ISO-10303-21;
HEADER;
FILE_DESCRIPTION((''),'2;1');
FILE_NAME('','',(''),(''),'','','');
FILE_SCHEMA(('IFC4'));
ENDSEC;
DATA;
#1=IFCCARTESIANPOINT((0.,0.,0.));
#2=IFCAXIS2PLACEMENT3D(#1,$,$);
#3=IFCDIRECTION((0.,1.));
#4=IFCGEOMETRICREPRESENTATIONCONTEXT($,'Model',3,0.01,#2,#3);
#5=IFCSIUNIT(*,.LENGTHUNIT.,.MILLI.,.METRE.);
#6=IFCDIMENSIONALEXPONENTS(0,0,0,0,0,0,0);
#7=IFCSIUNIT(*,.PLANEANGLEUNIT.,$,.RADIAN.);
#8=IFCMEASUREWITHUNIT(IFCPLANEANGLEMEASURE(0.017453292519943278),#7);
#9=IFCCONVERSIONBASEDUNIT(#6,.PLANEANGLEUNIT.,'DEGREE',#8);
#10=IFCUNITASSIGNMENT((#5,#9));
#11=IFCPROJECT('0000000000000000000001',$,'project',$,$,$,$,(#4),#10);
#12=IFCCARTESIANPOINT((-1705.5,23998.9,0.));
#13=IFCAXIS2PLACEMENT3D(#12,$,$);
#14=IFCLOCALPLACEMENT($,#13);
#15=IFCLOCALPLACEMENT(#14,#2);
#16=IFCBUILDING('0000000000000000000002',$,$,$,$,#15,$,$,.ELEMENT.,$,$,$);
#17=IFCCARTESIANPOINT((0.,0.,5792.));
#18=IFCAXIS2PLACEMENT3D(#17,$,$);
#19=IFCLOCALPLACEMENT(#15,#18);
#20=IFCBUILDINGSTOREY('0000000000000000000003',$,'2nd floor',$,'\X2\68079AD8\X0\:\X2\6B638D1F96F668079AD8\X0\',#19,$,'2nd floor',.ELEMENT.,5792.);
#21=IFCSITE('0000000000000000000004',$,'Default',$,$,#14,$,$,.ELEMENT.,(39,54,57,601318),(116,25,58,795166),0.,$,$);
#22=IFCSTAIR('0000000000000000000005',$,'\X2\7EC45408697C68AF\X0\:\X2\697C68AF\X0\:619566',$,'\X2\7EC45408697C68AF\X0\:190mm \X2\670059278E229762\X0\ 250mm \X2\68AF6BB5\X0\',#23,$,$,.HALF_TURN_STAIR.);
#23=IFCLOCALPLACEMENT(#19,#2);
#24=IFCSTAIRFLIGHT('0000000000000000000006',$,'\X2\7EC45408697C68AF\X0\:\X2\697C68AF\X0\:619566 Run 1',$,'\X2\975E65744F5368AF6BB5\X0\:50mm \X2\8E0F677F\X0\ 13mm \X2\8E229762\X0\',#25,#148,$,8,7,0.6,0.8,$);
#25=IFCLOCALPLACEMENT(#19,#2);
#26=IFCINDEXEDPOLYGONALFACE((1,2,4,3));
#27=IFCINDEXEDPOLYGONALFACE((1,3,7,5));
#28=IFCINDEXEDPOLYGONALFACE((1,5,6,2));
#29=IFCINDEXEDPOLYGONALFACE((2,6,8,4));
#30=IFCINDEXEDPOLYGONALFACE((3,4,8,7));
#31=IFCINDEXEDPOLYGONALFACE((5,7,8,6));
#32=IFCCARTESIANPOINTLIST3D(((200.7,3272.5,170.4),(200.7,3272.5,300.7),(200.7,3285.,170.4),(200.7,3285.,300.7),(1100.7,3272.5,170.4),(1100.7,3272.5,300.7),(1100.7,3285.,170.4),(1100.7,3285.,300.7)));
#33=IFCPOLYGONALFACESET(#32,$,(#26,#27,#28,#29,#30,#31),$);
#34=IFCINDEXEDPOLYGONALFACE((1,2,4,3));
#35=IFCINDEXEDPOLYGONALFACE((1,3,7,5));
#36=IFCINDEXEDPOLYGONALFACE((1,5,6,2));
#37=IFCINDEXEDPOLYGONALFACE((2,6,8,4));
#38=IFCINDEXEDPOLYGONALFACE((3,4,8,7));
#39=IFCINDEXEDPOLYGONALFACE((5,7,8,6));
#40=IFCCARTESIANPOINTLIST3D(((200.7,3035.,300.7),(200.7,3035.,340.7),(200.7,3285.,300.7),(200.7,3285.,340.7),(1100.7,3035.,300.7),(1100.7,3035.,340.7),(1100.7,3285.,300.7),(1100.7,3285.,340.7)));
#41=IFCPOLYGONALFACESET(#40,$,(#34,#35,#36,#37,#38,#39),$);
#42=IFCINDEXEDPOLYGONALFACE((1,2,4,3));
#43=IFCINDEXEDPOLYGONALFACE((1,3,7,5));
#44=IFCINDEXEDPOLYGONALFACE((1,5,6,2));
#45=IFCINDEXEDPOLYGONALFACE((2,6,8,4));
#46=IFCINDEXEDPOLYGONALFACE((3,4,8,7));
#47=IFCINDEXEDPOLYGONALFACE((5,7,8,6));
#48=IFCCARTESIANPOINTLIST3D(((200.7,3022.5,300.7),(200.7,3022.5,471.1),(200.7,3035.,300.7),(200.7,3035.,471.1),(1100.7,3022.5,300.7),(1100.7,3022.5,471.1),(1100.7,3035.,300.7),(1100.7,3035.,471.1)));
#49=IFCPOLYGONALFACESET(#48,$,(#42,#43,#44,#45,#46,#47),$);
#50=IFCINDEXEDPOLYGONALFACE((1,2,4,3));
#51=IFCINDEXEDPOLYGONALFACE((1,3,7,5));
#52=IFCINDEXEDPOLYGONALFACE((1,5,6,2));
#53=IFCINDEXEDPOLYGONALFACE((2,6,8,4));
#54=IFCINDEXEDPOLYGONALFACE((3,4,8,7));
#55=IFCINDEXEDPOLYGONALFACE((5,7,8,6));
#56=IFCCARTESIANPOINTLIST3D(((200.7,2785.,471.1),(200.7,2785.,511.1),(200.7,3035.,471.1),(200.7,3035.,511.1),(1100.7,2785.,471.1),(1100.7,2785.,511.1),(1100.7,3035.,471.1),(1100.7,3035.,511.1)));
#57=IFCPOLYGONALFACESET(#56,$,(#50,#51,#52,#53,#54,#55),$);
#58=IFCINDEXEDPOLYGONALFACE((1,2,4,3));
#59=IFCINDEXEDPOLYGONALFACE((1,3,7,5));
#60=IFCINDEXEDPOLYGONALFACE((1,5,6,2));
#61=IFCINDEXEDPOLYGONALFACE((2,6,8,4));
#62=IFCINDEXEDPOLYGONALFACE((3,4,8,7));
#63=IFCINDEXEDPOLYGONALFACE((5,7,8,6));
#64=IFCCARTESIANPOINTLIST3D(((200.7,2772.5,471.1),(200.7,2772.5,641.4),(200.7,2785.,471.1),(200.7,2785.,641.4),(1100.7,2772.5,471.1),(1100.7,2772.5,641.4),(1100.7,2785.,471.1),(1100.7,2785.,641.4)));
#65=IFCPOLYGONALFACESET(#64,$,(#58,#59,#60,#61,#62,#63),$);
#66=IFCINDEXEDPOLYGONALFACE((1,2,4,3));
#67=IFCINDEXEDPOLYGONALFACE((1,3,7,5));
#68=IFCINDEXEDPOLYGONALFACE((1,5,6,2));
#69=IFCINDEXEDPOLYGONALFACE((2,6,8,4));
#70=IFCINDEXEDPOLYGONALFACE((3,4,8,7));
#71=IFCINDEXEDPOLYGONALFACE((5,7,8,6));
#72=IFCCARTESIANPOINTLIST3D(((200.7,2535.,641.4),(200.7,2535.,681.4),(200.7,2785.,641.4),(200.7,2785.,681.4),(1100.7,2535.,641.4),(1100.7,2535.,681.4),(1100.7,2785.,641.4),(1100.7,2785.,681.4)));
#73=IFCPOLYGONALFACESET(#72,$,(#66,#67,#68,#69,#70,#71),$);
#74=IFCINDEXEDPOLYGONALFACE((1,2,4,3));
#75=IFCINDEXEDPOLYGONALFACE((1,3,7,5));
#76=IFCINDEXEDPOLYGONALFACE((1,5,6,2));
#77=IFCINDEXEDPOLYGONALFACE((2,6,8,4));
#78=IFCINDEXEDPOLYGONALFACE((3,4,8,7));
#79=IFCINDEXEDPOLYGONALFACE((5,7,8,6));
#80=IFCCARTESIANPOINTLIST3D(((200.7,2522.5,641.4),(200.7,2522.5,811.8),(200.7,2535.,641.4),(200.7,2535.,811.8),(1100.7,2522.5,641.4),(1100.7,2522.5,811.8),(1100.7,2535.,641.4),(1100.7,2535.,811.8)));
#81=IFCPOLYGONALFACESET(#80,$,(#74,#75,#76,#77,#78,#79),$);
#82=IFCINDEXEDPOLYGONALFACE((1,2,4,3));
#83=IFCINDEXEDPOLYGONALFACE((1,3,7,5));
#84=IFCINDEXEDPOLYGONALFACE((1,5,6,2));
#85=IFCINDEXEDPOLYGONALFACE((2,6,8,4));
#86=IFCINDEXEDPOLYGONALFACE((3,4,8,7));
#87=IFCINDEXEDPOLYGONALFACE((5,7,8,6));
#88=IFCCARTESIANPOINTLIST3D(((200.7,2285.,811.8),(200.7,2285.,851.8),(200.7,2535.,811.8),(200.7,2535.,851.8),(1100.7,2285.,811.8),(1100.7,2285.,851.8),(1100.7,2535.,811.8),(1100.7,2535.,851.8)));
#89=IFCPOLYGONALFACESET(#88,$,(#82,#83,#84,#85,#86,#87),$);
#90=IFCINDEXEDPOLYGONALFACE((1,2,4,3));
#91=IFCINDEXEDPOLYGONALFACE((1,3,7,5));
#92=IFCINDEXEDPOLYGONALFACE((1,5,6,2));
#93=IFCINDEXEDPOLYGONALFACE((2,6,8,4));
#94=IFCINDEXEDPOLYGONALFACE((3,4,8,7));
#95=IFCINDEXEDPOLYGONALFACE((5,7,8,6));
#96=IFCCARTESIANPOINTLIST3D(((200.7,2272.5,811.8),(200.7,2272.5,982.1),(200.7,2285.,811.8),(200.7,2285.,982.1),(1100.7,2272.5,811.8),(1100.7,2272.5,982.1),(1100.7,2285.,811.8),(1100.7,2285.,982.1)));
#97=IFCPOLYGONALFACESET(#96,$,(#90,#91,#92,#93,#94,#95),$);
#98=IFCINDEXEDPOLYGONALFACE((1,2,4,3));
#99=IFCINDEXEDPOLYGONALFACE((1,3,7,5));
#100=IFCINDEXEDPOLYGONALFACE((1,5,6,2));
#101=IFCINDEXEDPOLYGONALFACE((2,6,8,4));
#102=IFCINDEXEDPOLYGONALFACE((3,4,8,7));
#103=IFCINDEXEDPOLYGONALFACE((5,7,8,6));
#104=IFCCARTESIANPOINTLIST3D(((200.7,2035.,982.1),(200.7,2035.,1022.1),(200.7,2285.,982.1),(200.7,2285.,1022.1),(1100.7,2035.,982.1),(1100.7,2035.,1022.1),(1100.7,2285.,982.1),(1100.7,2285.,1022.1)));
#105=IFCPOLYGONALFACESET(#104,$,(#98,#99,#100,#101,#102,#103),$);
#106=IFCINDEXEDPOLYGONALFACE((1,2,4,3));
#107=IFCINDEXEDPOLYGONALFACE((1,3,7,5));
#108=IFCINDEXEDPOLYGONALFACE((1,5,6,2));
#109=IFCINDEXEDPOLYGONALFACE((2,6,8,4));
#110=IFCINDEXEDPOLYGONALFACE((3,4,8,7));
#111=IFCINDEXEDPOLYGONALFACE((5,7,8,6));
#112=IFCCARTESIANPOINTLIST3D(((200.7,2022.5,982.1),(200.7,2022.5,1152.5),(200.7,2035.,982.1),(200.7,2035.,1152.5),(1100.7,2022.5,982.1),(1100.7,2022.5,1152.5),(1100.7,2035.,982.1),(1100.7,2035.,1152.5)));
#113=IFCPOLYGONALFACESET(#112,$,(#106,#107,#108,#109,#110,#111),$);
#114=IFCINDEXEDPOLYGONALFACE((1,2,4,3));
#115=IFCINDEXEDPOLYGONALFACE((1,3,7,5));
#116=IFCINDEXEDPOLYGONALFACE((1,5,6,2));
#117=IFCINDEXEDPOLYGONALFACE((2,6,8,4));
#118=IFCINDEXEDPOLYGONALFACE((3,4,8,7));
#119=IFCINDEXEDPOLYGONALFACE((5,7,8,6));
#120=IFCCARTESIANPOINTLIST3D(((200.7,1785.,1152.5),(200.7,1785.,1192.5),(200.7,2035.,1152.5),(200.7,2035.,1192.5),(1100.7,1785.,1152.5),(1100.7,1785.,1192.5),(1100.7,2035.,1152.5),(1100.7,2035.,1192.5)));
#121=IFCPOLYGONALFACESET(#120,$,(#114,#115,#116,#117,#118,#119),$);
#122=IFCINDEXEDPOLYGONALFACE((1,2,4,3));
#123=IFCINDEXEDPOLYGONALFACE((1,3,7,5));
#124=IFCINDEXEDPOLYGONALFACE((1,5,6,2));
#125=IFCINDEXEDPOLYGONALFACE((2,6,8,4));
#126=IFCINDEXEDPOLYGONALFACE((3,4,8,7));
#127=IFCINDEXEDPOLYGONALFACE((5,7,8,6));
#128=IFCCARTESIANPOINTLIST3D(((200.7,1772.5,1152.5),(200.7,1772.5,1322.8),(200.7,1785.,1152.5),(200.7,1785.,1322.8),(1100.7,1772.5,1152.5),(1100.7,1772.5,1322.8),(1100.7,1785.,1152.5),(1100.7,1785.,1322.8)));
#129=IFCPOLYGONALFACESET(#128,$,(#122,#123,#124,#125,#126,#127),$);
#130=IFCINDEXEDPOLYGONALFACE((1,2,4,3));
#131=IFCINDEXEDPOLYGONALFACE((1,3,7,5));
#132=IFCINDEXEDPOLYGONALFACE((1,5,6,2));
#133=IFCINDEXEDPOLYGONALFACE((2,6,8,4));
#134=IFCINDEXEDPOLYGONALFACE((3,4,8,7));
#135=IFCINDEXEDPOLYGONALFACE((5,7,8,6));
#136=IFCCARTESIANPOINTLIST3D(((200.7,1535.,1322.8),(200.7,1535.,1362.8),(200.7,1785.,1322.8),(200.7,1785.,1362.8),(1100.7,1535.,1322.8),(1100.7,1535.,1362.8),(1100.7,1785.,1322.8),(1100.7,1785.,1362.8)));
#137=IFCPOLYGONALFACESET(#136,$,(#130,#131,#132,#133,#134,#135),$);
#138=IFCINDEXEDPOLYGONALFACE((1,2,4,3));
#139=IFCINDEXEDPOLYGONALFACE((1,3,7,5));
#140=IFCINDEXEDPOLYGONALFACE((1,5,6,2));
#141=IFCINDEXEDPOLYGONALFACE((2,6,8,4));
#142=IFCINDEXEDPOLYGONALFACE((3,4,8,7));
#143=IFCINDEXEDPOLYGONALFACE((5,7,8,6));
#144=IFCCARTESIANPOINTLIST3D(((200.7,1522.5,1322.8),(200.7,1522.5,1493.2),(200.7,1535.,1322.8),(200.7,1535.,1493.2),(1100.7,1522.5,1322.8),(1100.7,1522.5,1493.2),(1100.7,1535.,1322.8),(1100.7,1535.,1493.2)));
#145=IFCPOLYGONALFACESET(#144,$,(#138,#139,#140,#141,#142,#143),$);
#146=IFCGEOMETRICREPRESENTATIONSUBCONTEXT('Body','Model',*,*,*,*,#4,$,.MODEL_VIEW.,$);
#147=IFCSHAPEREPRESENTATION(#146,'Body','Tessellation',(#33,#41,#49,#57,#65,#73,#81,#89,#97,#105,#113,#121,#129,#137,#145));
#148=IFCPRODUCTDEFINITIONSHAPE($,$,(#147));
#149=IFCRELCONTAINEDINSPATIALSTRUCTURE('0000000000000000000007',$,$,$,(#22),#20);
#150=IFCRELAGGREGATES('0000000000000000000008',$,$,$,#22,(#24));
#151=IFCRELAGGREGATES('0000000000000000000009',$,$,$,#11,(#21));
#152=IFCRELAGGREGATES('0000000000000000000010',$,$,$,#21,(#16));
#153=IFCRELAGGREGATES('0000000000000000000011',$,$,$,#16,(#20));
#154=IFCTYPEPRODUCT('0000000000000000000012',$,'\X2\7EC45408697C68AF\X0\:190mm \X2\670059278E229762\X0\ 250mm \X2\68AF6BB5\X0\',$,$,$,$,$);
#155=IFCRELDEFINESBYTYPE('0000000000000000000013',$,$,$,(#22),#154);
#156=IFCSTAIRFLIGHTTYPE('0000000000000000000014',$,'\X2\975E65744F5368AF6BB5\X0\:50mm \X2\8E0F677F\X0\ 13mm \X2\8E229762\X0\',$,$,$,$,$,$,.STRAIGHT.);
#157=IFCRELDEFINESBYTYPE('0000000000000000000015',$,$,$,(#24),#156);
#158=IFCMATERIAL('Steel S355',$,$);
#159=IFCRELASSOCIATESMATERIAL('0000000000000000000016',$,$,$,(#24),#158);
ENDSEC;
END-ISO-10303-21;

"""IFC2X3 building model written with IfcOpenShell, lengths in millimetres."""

from ifc_helpers import new_model, entity, si_unit, converted_unit, direction, frame, frame_2d, origin, origin_2d_with_axis, place, context, subcontext, project, spatial, rectangle, extrude, material, type_object, element, aggregate, save


model = new_model("IFC2X3")

# Units and contexts
model_context = context("Model", 3, precision=0.01, world=origin(), true_north=direction((0.0, 1.0)))
body_context = subcontext(model_context, "Body", "Model", "MODEL_VIEW")
ifc_project = project(units=[si_unit("LENGTHUNIT", "METRE", prefix="MILLI"), converted_unit("PLANEANGLEUNIT", "DEGREE", entity("IfcPlaneAngleMeasure", 0.017453292519943278), si_unit("PLANEANGLEUNIT", "RADIAN"), dimensions=[0, 0, 0, 0, 0, 0, 0])], contexts=[model_context])

# Site, building, storey
site_placement = place(None, frame((-1705.5, 23998.9, 0.0)))
site = spatial("IfcSite", under=ifc_project, at=site_placement, Name="Default", CompositionType="ELEMENT", RefLatitude=(39, 54, 57, 601318), RefLongitude=(116, 25, 58, 795166), RefElevation=0.0)
building_placement = place(site_placement, origin())
building = spatial("IfcBuilding", under=site, at=building_placement, CompositionType="ELEMENT")
storey_placement = place(building_placement, frame((0.0, 0.0, 5792.0)))
storey = spatial("IfcBuildingStorey", under=building, at=storey_placement, Name="2nd floor", ObjectType="标高:正负零标高", LongName="2nd floor", CompositionType="ELEMENT", Elevation=5792.0)

# Stair
type_product = type_object("IfcTypeProduct", Name="组合楼梯:190mm 最大踢面 250mm 梯段")
stair_placement = place(storey_placement, origin())
stair = element("IfcStair", 1, at=stair_placement, inside=storey, type_object=type_product, Name="组合楼梯:楼梯:619566", ObjectType="组合楼梯:190mm 最大踢面 250mm 梯段", ShapeType="HALF_TURN_STAIR")
ifc_material_1 = material(Name="Steel S355")

# Stair flight
stair_flight_type = type_object("IfcStairFlightType", Name="非整体梯段:50mm 踏板 13mm 踢面", PredefinedType="STRAIGHT")
stair_flight_1_placement = place(stair_placement, origin())
stair_flight_1 = element("IfcStairFlight", 2, at=stair_flight_1_placement, type_object=stair_flight_type, material=ifc_material_1, Name="组合楼梯:楼梯:619566 Run 1", ObjectType="非整体梯段:50mm 踏板 13mm 踢面", NumberOfRiser=8, NumberOfTreads=7, RiserHeight=0.6, TreadLength=0.8, context=body_context, shape_type="SweptSolid", body=[
    extrude(rectangle(XDim=900.0, YDim=12.5, at=frame_2d((0.0, 0.0), x_axis=(1.0, 0.0))), frame((650.7, 3278.7, 170.4)), (0.0, 0.0, 1.0), 130.4),
    extrude(rectangle(XDim=250.0, YDim=900.0, at=frame_2d((0.0, 0.0), x_axis=(1.0, 0.0))), frame((650.7, 3160.0, 300.7), z_axis=(0.0, 0.0, 1.0), x_axis=(0.0, 1.0, 0.0)), (0.0, 0.0, 1.0), 40.0),
    extrude(rectangle(XDim=900.0, YDim=12.5, at=frame_2d((0.0, 0.0), x_axis=(1.0, 0.0))), frame((650.7, 3028.7, 300.7)), (0.0, 0.0, 1.0), 170.4),
    extrude(rectangle(XDim=250.0, YDim=900.0, at=frame_2d((0.0, 0.0), x_axis=(1.0, 0.0))), frame((650.7, 2910.0, 471.1), z_axis=(0.0, 0.0, 1.0), x_axis=(0.0, 1.0, 0.0)), (0.0, 0.0, 1.0), 40.0),
    extrude(rectangle(XDim=900.0, YDim=12.5, at=frame_2d((0.0, 0.0), x_axis=(1.0, 0.0))), frame((650.7, 2778.7, 471.1)), (0.0, 0.0, 1.0), 170.4),
    extrude(rectangle(XDim=250.0, YDim=900.0, at=frame_2d((0.0, 0.0), x_axis=(1.0, 0.0))), frame((650.7, 2660.0, 641.4), z_axis=(0.0, 0.0, 1.0), x_axis=(0.0, 1.0, 0.0)), (0.0, 0.0, 1.0), 40.0),
    extrude(rectangle(XDim=900.0, YDim=12.5, at=frame_2d((0.0, 0.0), x_axis=(1.0, 0.0))), frame((650.7, 2528.7, 641.4)), (0.0, 0.0, 1.0), 170.4),
    extrude(rectangle(XDim=250.0, YDim=900.0, at=origin_2d_with_axis()), frame((650.7, 2410.0, 811.8), z_axis=(0.0, 0.0, 1.0), x_axis=(0.0, 1.0, 0.0)), (0.0, 0.0, 1.0), 40.0),
    extrude(rectangle(XDim=900.0, YDim=12.5, at=origin_2d_with_axis()), frame((650.7, 2278.7, 811.8)), (0.0, 0.0, 1.0), 170.4),
    extrude(rectangle(XDim=250.0, YDim=900.0, at=origin_2d_with_axis()), frame((650.7, 2160.0, 982.1), z_axis=(0.0, 0.0, 1.0), x_axis=(0.0, 1.0, 0.0)), (0.0, 0.0, 1.0), 40.0),
    extrude(rectangle(XDim=900.0, YDim=12.5, at=origin_2d_with_axis()), frame((650.7, 2028.7, 982.1)), (0.0, 0.0, 1.0), 170.4),
    extrude(rectangle(XDim=250.0, YDim=900.0, at=frame_2d((0.0, 0.0), x_axis=(1.0, 0.0))), frame((650.7, 1910.0, 1152.5), z_axis=(0.0, 0.0, 1.0), x_axis=(0.0, 1.0, 0.0)), (0.0, 0.0, 1.0), 40.0),
    extrude(rectangle(XDim=900.0, YDim=12.5, at=origin_2d_with_axis()), frame((650.7, 1778.7, 1152.5)), (0.0, 0.0, 1.0), 170.4),
    extrude(rectangle(XDim=250.0, YDim=900.0, at=origin_2d_with_axis()), frame((650.7, 1660.0, 1322.8), z_axis=(0.0, 0.0, 1.0), x_axis=(0.0, 1.0, 0.0)), (0.0, 0.0, 1.0), 40.0),
    extrude(rectangle(XDim=900.0, YDim=12.5, at=origin_2d_with_axis()), frame((650.7, 1528.7, 1322.8)), (0.0, 0.0, 1.0), 170.4),
])
aggregate(stair, [stair_flight_1])

save(model, "model.ifc")
